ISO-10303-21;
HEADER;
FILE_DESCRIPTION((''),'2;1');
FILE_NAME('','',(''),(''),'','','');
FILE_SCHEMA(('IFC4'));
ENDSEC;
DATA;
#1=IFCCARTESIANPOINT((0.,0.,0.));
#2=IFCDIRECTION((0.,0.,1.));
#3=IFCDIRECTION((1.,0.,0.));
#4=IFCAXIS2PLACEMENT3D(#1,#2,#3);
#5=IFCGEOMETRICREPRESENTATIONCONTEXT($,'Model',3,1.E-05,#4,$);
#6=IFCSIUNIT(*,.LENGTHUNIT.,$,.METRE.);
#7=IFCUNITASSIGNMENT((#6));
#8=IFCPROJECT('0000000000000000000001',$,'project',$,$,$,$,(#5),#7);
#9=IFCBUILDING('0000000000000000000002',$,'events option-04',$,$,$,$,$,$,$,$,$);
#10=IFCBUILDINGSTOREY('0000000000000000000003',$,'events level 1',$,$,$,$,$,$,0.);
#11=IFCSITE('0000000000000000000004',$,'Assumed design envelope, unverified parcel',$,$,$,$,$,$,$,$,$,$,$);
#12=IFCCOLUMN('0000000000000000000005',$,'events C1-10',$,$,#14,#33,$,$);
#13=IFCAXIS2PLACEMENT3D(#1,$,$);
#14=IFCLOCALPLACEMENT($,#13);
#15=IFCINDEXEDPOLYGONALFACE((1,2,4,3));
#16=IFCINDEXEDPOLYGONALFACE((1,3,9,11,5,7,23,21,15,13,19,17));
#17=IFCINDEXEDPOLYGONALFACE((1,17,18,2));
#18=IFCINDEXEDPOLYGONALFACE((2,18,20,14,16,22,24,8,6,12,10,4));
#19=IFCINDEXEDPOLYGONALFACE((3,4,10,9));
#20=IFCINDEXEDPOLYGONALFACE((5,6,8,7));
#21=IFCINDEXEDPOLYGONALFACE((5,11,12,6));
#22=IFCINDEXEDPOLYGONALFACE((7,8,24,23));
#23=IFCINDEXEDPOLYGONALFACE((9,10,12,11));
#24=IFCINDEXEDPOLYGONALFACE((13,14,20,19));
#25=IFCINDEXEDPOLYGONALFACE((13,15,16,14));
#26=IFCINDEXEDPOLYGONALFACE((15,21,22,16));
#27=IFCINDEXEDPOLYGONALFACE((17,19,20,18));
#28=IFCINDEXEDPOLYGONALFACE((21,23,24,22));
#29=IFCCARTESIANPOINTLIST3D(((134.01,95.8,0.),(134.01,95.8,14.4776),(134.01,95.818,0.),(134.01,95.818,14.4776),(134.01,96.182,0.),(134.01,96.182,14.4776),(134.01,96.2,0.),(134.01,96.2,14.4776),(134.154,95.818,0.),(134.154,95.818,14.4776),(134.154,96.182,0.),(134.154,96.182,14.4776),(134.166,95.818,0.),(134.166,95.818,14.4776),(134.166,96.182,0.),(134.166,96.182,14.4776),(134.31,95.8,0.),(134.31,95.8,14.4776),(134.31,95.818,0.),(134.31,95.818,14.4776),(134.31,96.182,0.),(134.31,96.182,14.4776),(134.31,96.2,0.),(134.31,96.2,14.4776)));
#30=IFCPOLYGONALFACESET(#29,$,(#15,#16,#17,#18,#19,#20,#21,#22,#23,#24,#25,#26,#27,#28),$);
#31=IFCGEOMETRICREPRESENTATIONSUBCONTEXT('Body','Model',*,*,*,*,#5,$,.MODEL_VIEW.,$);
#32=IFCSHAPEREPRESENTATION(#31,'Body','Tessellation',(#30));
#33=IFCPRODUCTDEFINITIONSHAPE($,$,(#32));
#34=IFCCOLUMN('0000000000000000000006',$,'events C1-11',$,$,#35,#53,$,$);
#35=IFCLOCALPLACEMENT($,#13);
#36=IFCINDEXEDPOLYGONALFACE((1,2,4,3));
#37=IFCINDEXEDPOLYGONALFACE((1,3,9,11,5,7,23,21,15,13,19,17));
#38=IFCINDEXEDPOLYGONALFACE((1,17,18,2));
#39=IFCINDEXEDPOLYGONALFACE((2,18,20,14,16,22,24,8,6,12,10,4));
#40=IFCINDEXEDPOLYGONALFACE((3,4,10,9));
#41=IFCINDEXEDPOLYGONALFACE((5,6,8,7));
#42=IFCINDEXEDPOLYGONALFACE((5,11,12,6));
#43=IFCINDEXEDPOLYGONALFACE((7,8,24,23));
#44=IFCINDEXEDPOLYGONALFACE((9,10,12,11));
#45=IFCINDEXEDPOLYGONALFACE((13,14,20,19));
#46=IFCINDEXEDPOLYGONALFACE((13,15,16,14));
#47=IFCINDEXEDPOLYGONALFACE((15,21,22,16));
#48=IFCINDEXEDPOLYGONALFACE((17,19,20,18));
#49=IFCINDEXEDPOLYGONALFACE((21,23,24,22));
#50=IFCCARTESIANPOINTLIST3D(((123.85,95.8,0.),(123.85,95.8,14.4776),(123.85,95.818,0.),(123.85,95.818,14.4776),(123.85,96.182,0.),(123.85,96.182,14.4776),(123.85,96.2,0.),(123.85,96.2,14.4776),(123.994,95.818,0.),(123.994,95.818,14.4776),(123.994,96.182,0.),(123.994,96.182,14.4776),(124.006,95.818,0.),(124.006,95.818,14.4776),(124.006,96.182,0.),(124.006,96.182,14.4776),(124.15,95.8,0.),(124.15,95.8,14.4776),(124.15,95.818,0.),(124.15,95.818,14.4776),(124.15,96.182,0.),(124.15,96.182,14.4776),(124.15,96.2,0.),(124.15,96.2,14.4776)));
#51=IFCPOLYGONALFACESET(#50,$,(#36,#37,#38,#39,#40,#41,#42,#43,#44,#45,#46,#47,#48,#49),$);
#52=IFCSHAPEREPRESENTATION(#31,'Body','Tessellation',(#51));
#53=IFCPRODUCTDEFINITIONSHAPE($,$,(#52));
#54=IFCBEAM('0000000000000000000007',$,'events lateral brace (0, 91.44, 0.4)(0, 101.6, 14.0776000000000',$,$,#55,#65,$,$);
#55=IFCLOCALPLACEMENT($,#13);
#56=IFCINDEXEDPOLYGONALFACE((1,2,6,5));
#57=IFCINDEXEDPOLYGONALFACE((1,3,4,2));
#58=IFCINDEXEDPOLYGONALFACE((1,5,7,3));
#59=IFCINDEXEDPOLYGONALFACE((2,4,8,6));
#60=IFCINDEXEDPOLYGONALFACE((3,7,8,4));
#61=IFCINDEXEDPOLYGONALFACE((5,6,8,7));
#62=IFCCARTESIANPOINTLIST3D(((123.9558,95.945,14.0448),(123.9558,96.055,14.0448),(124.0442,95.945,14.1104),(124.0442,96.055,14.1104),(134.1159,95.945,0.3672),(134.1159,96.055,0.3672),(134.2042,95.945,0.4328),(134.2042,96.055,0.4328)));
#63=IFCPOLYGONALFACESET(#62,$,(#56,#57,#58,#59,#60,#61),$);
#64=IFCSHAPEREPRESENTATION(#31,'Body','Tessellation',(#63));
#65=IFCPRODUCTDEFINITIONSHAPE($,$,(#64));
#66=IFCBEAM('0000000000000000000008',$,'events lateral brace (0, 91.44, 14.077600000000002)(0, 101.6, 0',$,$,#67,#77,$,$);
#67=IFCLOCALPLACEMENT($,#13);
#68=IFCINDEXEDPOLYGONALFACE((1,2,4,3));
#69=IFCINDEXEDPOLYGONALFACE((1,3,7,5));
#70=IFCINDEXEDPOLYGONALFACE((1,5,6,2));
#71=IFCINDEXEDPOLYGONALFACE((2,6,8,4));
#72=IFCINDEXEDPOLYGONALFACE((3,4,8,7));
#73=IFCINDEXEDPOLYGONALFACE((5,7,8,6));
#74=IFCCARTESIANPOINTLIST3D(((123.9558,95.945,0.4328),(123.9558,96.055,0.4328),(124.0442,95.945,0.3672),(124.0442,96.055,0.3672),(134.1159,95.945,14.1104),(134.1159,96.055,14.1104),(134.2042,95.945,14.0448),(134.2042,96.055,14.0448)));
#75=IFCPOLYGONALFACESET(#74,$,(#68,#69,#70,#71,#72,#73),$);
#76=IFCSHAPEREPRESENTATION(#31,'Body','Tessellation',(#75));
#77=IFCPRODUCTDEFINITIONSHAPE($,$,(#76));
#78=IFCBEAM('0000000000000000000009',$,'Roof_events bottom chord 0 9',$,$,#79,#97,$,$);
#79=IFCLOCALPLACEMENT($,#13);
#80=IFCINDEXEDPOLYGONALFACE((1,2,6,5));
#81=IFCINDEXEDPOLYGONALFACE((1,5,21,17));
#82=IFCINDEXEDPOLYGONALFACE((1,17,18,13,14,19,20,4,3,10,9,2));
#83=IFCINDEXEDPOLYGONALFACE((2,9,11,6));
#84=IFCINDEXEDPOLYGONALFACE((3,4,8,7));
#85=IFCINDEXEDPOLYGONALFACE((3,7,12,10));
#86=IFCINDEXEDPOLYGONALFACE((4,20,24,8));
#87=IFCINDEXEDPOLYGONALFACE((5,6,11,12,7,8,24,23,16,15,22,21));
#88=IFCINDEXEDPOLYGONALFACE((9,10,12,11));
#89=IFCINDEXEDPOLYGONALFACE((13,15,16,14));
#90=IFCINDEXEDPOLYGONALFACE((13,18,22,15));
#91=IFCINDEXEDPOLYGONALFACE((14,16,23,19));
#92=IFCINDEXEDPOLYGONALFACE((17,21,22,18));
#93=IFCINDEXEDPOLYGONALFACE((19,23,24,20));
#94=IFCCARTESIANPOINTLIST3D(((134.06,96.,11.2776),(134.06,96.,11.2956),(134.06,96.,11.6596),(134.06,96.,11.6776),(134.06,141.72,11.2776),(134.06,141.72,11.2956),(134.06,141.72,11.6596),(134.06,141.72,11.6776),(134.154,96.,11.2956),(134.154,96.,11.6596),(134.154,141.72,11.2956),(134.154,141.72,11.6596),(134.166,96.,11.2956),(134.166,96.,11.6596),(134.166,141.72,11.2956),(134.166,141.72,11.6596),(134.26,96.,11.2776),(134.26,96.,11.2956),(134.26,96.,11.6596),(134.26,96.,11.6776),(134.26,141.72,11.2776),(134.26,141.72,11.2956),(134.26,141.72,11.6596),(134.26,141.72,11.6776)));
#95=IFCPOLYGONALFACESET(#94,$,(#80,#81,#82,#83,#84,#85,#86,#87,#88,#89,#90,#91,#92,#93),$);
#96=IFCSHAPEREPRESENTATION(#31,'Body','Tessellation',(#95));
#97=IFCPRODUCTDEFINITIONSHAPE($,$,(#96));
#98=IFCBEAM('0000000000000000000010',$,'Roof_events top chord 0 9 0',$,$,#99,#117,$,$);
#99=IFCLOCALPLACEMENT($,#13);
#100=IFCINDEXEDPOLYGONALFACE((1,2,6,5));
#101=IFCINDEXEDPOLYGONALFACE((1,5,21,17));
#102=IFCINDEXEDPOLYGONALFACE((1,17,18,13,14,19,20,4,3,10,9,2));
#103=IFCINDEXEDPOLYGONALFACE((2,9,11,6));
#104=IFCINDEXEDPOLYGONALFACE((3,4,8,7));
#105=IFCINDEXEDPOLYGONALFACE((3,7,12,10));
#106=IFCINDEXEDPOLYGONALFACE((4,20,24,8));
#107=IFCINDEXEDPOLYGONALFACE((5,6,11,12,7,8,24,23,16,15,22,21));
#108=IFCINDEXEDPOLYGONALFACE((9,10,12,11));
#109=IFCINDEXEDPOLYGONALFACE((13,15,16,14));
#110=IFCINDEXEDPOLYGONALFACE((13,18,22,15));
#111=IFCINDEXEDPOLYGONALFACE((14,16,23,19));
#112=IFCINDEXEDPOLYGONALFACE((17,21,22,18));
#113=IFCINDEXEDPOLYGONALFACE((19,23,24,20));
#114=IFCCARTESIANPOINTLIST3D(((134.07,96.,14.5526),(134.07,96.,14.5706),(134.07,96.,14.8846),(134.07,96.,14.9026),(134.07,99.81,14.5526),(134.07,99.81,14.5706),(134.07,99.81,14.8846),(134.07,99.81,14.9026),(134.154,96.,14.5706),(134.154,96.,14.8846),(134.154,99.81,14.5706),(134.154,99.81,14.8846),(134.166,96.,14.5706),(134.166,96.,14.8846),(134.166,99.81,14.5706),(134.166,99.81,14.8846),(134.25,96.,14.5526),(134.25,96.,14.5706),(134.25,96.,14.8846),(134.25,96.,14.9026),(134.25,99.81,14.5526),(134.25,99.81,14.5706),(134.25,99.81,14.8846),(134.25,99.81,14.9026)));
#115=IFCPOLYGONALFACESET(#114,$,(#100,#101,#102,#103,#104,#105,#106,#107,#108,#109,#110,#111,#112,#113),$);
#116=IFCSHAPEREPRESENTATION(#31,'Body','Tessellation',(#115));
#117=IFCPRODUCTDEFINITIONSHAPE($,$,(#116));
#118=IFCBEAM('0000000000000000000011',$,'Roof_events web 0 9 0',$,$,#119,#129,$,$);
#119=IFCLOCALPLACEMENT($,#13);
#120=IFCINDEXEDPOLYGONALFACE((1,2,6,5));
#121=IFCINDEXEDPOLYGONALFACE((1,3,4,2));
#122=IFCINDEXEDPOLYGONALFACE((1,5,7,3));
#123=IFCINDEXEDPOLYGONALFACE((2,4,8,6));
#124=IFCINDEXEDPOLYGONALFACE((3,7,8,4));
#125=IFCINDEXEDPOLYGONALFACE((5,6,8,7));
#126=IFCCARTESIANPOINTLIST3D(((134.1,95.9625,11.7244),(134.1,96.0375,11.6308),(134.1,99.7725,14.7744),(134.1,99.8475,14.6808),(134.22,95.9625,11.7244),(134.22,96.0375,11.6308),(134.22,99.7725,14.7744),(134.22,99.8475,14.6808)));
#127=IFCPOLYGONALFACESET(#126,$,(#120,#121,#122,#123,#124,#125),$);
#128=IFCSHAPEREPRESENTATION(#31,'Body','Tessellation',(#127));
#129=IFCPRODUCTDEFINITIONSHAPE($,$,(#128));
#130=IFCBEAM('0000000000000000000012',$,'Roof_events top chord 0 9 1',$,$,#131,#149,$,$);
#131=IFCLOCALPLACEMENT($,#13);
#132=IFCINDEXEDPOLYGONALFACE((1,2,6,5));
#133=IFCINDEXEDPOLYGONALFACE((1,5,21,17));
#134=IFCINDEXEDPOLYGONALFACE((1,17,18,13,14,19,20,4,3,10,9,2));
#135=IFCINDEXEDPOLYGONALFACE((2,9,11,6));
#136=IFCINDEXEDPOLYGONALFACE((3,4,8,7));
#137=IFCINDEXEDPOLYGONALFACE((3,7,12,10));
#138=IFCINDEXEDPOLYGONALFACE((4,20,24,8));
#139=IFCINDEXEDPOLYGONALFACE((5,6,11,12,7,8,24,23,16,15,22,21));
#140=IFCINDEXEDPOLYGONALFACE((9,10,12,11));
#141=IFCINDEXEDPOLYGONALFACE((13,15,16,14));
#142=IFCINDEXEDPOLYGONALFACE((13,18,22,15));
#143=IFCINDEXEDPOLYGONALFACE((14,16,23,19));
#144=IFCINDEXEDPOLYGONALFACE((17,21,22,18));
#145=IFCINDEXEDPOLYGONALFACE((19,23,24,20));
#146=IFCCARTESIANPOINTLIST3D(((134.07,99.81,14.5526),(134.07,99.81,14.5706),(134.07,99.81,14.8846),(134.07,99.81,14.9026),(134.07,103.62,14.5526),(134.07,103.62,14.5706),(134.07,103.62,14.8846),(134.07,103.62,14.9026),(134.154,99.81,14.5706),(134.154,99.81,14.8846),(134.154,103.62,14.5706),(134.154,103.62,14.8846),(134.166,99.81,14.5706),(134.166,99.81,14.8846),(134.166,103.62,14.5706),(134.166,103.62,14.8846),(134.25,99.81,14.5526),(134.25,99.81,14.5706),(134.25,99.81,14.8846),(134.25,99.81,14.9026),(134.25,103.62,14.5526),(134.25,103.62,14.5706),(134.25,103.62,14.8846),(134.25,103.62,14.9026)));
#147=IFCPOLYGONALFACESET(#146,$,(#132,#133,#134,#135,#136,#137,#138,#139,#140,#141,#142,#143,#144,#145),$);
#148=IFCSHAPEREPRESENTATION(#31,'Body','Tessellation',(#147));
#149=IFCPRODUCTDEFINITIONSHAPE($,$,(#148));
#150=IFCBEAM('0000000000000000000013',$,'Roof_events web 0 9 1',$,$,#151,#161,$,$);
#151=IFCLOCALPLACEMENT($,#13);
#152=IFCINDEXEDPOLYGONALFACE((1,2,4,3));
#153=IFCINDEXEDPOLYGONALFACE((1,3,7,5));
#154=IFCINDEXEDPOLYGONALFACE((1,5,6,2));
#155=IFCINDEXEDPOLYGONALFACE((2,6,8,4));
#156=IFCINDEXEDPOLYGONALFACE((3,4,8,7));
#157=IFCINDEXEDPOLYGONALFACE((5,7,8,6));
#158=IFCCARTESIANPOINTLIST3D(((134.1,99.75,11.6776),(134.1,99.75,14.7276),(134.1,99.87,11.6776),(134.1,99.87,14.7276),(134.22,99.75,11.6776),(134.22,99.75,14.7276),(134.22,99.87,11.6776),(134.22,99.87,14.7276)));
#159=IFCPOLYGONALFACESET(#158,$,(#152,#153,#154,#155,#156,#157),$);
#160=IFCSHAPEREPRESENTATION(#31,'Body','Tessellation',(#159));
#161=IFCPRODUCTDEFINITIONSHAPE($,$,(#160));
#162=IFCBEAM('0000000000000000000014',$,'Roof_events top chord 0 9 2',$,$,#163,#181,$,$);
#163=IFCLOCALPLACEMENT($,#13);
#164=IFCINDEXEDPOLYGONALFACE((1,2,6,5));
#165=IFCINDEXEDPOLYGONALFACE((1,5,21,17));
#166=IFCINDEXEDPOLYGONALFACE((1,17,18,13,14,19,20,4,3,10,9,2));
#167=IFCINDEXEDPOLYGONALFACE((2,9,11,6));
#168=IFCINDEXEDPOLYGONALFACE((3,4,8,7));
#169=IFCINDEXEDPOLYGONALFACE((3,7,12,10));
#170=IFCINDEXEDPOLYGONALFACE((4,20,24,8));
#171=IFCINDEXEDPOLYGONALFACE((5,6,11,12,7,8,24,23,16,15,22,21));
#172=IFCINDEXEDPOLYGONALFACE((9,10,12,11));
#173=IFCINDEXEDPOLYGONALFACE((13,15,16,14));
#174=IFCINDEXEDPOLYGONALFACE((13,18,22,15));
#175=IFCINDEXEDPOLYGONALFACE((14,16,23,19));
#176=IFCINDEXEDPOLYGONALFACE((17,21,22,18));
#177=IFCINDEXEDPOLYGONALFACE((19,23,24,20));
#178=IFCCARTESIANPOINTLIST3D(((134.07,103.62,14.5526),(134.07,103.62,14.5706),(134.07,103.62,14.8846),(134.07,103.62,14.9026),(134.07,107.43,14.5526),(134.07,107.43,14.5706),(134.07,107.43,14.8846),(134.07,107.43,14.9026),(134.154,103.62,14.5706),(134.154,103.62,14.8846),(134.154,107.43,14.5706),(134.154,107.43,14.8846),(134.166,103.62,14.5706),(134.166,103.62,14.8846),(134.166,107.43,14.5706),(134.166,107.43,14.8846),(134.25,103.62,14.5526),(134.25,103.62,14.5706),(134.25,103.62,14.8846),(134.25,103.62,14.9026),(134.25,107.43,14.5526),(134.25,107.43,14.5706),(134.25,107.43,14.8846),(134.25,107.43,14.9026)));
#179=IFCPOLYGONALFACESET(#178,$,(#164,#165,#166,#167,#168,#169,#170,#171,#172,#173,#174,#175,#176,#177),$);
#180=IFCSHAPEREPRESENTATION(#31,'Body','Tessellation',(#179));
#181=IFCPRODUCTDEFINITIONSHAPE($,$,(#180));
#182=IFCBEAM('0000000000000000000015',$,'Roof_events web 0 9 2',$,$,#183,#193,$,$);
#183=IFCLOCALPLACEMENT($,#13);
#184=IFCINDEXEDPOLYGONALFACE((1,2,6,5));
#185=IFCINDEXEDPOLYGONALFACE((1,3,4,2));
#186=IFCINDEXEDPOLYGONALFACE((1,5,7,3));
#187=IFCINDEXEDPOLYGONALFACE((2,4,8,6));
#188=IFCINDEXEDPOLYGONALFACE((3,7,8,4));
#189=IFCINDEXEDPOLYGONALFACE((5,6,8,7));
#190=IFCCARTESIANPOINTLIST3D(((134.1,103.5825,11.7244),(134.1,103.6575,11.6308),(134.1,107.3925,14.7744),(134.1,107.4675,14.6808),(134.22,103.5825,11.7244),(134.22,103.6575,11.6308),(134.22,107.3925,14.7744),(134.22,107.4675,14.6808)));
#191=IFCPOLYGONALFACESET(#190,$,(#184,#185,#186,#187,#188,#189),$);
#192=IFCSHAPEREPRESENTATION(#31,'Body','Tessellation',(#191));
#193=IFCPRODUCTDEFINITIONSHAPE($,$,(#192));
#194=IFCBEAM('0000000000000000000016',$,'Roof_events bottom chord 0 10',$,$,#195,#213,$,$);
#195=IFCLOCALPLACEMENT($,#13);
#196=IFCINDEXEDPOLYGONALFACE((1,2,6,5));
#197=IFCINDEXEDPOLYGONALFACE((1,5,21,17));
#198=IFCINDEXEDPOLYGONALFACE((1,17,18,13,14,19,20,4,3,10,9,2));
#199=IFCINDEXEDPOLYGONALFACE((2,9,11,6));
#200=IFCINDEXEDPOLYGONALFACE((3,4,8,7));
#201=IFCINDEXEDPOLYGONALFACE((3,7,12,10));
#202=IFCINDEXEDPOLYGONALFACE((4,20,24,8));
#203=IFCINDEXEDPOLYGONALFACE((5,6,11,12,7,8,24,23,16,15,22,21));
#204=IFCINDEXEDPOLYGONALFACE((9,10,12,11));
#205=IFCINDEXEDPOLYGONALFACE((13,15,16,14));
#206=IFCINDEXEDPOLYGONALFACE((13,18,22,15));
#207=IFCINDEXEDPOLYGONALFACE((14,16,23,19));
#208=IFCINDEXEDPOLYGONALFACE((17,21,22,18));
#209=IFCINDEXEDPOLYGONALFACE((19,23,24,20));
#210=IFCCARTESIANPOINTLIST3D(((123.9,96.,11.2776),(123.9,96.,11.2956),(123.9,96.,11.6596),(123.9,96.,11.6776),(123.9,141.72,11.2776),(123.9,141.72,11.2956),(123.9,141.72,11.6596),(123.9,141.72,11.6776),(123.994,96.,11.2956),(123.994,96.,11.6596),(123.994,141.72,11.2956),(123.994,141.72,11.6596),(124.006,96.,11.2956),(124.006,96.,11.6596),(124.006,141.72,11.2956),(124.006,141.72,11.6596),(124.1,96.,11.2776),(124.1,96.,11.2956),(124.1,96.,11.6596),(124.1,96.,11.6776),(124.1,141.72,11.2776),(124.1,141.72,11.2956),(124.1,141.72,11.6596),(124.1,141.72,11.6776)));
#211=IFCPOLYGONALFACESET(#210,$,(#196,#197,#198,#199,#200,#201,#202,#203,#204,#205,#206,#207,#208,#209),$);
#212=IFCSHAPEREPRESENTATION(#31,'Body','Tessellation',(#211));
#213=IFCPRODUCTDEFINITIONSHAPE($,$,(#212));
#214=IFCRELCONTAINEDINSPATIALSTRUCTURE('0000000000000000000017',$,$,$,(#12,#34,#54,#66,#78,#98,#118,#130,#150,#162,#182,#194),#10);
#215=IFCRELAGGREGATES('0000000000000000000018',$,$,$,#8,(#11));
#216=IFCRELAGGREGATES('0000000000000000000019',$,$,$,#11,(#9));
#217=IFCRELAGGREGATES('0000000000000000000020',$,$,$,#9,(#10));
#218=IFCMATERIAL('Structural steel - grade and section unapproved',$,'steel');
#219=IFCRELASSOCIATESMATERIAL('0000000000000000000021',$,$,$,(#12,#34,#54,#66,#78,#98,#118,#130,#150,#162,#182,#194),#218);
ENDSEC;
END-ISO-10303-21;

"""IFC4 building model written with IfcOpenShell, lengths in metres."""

from ifc_helpers import new_model, si_unit, frame, origin_with_axes, place, context, subcontext, project, spatial, rectangle, i_section, extrude, material, element, save


model = new_model("IFC4")

# Units and contexts
model_context = context("Model", 3, precision=1e-05, world=origin_with_axes())
body_context = subcontext(model_context, "Body", "Model", "MODEL_VIEW")
ifc_project = project(units=[si_unit("LENGTHUNIT", "METRE")], contexts=[model_context])

# Site, building, storey
site = spatial("IfcSite", under=ifc_project, Name="Assumed design envelope, unverified parcel")
building = spatial("IfcBuilding", under=site, Name="events option-04")
storey = spatial("IfcBuildingStorey", under=building, Name="events level 1", Elevation=0.0)

# Columns
ifc_material_1 = material(Name="Structural steel - grade and section unapproved", Category="steel")
for number, where, z_axis, x_axis, name in (
    (1, (134.16, 96.0, 0.0), (0.0, 0.0, 1.0), (-1.0, 0.0, 0.0), "events C1-10"),
    (2, (124.0, 96.0, 0.0), (0.0, 0.0, 1.0), (-1.0, 0.0, 0.0), "events C1-11"),
):
    element("IfcColumn", number, at=place(None, frame(where, z_axis=z_axis, x_axis=x_axis)), inside=storey, material=ifc_material_1, Name=name, context=body_context, shape_type="SweptSolid", body=[
        extrude(i_section(OverallWidth=0.3, OverallDepth=0.4, WebThickness=0.012, FlangeThickness=0.018, FilletRadius=0.0), origin_with_axes(), (0.0, 0.0, 1.0), 14.4776),
    ])

# Beams
for number, where, z_axis, x_axis, name in (
    (3, (134.16, 96.0, 0.4), (-0.596305, 0.0, 0.802758), (0.0, -1.0, 0.0), "events lateral brace (0, 91.44, 0.4)(0, 101.6, 14.0776000000000"),
    (4, (134.16, 96.0, 14.0776), (-0.596305, 0.0, -0.802758), (0.0, -1.0, 0.0), "events lateral brace (0, 91.44, 14.077600000000002)(0, 101.6, 0"),
):
    element("IfcBeam", number, at=place(None, frame(where, z_axis=z_axis, x_axis=x_axis)), inside=storey, material=ifc_material_1, Name=name, context=body_context, shape_type="SweptSolid", body=[
        extrude(rectangle(XDim=0.11, YDim=0.11), origin_with_axes(), (0.0, 0.0, 1.0), 17.0383),
    ])
beam_1_placement = place(None, frame((134.16, 96.0, 11.4776), z_axis=(0.0, 1.0, 0.0), x_axis=(-1.0, 0.0, 0.0)))
element("IfcBeam", 5, at=beam_1_placement, inside=storey, material=ifc_material_1, Name="Roof_events bottom chord 0 9", context=body_context, shape_type="SweptSolid", body=[
    extrude(i_section(OverallWidth=0.2, OverallDepth=0.4, WebThickness=0.012, FlangeThickness=0.018, FilletRadius=0.0), origin_with_axes(), (0.0, 0.0, 1.0), 45.72),
])
beam_2_placement = place(None, frame((134.16, 96.0, 14.7276), z_axis=(0.0, 1.0, 0.0), x_axis=(-1.0, 0.0, 0.0)))
element("IfcBeam", 6, at=beam_2_placement, inside=storey, material=ifc_material_1, Name="Roof_events top chord 0 9 0", context=body_context, shape_type="SweptSolid", body=[
    extrude(i_section(OverallWidth=0.18, OverallDepth=0.35, WebThickness=0.012, FlangeThickness=0.018, FilletRadius=0.0), origin_with_axes(), (0.0, 0.0, 1.0), 3.81),
])
beam_3_placement = place(None, frame((134.16, 96.0, 11.6776), z_axis=(0.0, 0.780669, 0.624945), x_axis=(-1.0, 0.0, 0.0)))
element("IfcBeam", 7, at=beam_3_placement, inside=storey, material=ifc_material_1, Name="Roof_events web 0 9 0", context=body_context, shape_type="SweptSolid", body=[
    extrude(rectangle(XDim=0.12, YDim=0.12), origin_with_axes(), (0.0, 0.0, 1.0), 4.8804),
])
beam_4_placement = place(None, frame((134.16, 99.81, 14.7276), z_axis=(0.0, 1.0, 0.0), x_axis=(-1.0, 0.0, 0.0)))
element("IfcBeam", 8, at=beam_4_placement, inside=storey, material=ifc_material_1, Name="Roof_events top chord 0 9 1", context=body_context, shape_type="SweptSolid", body=[
    extrude(i_section(OverallWidth=0.18, OverallDepth=0.35, WebThickness=0.012, FlangeThickness=0.018, FilletRadius=0.0), origin_with_axes(), (0.0, 0.0, 1.0), 3.81),
])
beam_5_placement = place(None, frame((134.16, 99.81, 11.6776), z_axis=(0.0, 0.0, 1.0), x_axis=(-1.0, 0.0, 0.0)))
element("IfcBeam", 9, at=beam_5_placement, inside=storey, material=ifc_material_1, Name="Roof_events web 0 9 1", context=body_context, shape_type="SweptSolid", body=[
    extrude(rectangle(XDim=0.12, YDim=0.12), origin_with_axes(), (0.0, 0.0, 1.0), 3.05),
])
beam_6_placement = place(None, frame((134.16, 103.62, 14.7276), z_axis=(0.0, 1.0, 0.0), x_axis=(-1.0, 0.0, 0.0)))
element("IfcBeam", 10, at=beam_6_placement, inside=storey, material=ifc_material_1, Name="Roof_events top chord 0 9 2", context=body_context, shape_type="SweptSolid", body=[
    extrude(i_section(OverallWidth=0.18, OverallDepth=0.35, WebThickness=0.012, FlangeThickness=0.018, FilletRadius=0.0), origin_with_axes(), (0.0, 0.0, 1.0), 3.81),
])
beam_7_placement = place(None, frame((134.16, 103.62, 11.6776), z_axis=(0.0, 0.780669, 0.624945), x_axis=(-1.0, 0.0, 0.0)))
element("IfcBeam", 11, at=beam_7_placement, inside=storey, material=ifc_material_1, Name="Roof_events web 0 9 2", context=body_context, shape_type="SweptSolid", body=[
    extrude(rectangle(XDim=0.12, YDim=0.12), origin_with_axes(), (0.0, 0.0, 1.0), 4.8804),
])
beam_8_placement = place(None, frame((124.0, 96.0, 11.4776), z_axis=(0.0, 1.0, 0.0), x_axis=(-1.0, 0.0, 0.0)))
element("IfcBeam", 12, at=beam_8_placement, inside=storey, material=ifc_material_1, Name="Roof_events bottom chord 0 10", context=body_context, shape_type="SweptSolid", body=[
    extrude(i_section(OverallWidth=0.2, OverallDepth=0.4, WebThickness=0.012, FlangeThickness=0.018, FilletRadius=0.0), origin_with_axes(), (0.0, 0.0, 1.0), 45.72),
])

save(model, "model.ifc")
